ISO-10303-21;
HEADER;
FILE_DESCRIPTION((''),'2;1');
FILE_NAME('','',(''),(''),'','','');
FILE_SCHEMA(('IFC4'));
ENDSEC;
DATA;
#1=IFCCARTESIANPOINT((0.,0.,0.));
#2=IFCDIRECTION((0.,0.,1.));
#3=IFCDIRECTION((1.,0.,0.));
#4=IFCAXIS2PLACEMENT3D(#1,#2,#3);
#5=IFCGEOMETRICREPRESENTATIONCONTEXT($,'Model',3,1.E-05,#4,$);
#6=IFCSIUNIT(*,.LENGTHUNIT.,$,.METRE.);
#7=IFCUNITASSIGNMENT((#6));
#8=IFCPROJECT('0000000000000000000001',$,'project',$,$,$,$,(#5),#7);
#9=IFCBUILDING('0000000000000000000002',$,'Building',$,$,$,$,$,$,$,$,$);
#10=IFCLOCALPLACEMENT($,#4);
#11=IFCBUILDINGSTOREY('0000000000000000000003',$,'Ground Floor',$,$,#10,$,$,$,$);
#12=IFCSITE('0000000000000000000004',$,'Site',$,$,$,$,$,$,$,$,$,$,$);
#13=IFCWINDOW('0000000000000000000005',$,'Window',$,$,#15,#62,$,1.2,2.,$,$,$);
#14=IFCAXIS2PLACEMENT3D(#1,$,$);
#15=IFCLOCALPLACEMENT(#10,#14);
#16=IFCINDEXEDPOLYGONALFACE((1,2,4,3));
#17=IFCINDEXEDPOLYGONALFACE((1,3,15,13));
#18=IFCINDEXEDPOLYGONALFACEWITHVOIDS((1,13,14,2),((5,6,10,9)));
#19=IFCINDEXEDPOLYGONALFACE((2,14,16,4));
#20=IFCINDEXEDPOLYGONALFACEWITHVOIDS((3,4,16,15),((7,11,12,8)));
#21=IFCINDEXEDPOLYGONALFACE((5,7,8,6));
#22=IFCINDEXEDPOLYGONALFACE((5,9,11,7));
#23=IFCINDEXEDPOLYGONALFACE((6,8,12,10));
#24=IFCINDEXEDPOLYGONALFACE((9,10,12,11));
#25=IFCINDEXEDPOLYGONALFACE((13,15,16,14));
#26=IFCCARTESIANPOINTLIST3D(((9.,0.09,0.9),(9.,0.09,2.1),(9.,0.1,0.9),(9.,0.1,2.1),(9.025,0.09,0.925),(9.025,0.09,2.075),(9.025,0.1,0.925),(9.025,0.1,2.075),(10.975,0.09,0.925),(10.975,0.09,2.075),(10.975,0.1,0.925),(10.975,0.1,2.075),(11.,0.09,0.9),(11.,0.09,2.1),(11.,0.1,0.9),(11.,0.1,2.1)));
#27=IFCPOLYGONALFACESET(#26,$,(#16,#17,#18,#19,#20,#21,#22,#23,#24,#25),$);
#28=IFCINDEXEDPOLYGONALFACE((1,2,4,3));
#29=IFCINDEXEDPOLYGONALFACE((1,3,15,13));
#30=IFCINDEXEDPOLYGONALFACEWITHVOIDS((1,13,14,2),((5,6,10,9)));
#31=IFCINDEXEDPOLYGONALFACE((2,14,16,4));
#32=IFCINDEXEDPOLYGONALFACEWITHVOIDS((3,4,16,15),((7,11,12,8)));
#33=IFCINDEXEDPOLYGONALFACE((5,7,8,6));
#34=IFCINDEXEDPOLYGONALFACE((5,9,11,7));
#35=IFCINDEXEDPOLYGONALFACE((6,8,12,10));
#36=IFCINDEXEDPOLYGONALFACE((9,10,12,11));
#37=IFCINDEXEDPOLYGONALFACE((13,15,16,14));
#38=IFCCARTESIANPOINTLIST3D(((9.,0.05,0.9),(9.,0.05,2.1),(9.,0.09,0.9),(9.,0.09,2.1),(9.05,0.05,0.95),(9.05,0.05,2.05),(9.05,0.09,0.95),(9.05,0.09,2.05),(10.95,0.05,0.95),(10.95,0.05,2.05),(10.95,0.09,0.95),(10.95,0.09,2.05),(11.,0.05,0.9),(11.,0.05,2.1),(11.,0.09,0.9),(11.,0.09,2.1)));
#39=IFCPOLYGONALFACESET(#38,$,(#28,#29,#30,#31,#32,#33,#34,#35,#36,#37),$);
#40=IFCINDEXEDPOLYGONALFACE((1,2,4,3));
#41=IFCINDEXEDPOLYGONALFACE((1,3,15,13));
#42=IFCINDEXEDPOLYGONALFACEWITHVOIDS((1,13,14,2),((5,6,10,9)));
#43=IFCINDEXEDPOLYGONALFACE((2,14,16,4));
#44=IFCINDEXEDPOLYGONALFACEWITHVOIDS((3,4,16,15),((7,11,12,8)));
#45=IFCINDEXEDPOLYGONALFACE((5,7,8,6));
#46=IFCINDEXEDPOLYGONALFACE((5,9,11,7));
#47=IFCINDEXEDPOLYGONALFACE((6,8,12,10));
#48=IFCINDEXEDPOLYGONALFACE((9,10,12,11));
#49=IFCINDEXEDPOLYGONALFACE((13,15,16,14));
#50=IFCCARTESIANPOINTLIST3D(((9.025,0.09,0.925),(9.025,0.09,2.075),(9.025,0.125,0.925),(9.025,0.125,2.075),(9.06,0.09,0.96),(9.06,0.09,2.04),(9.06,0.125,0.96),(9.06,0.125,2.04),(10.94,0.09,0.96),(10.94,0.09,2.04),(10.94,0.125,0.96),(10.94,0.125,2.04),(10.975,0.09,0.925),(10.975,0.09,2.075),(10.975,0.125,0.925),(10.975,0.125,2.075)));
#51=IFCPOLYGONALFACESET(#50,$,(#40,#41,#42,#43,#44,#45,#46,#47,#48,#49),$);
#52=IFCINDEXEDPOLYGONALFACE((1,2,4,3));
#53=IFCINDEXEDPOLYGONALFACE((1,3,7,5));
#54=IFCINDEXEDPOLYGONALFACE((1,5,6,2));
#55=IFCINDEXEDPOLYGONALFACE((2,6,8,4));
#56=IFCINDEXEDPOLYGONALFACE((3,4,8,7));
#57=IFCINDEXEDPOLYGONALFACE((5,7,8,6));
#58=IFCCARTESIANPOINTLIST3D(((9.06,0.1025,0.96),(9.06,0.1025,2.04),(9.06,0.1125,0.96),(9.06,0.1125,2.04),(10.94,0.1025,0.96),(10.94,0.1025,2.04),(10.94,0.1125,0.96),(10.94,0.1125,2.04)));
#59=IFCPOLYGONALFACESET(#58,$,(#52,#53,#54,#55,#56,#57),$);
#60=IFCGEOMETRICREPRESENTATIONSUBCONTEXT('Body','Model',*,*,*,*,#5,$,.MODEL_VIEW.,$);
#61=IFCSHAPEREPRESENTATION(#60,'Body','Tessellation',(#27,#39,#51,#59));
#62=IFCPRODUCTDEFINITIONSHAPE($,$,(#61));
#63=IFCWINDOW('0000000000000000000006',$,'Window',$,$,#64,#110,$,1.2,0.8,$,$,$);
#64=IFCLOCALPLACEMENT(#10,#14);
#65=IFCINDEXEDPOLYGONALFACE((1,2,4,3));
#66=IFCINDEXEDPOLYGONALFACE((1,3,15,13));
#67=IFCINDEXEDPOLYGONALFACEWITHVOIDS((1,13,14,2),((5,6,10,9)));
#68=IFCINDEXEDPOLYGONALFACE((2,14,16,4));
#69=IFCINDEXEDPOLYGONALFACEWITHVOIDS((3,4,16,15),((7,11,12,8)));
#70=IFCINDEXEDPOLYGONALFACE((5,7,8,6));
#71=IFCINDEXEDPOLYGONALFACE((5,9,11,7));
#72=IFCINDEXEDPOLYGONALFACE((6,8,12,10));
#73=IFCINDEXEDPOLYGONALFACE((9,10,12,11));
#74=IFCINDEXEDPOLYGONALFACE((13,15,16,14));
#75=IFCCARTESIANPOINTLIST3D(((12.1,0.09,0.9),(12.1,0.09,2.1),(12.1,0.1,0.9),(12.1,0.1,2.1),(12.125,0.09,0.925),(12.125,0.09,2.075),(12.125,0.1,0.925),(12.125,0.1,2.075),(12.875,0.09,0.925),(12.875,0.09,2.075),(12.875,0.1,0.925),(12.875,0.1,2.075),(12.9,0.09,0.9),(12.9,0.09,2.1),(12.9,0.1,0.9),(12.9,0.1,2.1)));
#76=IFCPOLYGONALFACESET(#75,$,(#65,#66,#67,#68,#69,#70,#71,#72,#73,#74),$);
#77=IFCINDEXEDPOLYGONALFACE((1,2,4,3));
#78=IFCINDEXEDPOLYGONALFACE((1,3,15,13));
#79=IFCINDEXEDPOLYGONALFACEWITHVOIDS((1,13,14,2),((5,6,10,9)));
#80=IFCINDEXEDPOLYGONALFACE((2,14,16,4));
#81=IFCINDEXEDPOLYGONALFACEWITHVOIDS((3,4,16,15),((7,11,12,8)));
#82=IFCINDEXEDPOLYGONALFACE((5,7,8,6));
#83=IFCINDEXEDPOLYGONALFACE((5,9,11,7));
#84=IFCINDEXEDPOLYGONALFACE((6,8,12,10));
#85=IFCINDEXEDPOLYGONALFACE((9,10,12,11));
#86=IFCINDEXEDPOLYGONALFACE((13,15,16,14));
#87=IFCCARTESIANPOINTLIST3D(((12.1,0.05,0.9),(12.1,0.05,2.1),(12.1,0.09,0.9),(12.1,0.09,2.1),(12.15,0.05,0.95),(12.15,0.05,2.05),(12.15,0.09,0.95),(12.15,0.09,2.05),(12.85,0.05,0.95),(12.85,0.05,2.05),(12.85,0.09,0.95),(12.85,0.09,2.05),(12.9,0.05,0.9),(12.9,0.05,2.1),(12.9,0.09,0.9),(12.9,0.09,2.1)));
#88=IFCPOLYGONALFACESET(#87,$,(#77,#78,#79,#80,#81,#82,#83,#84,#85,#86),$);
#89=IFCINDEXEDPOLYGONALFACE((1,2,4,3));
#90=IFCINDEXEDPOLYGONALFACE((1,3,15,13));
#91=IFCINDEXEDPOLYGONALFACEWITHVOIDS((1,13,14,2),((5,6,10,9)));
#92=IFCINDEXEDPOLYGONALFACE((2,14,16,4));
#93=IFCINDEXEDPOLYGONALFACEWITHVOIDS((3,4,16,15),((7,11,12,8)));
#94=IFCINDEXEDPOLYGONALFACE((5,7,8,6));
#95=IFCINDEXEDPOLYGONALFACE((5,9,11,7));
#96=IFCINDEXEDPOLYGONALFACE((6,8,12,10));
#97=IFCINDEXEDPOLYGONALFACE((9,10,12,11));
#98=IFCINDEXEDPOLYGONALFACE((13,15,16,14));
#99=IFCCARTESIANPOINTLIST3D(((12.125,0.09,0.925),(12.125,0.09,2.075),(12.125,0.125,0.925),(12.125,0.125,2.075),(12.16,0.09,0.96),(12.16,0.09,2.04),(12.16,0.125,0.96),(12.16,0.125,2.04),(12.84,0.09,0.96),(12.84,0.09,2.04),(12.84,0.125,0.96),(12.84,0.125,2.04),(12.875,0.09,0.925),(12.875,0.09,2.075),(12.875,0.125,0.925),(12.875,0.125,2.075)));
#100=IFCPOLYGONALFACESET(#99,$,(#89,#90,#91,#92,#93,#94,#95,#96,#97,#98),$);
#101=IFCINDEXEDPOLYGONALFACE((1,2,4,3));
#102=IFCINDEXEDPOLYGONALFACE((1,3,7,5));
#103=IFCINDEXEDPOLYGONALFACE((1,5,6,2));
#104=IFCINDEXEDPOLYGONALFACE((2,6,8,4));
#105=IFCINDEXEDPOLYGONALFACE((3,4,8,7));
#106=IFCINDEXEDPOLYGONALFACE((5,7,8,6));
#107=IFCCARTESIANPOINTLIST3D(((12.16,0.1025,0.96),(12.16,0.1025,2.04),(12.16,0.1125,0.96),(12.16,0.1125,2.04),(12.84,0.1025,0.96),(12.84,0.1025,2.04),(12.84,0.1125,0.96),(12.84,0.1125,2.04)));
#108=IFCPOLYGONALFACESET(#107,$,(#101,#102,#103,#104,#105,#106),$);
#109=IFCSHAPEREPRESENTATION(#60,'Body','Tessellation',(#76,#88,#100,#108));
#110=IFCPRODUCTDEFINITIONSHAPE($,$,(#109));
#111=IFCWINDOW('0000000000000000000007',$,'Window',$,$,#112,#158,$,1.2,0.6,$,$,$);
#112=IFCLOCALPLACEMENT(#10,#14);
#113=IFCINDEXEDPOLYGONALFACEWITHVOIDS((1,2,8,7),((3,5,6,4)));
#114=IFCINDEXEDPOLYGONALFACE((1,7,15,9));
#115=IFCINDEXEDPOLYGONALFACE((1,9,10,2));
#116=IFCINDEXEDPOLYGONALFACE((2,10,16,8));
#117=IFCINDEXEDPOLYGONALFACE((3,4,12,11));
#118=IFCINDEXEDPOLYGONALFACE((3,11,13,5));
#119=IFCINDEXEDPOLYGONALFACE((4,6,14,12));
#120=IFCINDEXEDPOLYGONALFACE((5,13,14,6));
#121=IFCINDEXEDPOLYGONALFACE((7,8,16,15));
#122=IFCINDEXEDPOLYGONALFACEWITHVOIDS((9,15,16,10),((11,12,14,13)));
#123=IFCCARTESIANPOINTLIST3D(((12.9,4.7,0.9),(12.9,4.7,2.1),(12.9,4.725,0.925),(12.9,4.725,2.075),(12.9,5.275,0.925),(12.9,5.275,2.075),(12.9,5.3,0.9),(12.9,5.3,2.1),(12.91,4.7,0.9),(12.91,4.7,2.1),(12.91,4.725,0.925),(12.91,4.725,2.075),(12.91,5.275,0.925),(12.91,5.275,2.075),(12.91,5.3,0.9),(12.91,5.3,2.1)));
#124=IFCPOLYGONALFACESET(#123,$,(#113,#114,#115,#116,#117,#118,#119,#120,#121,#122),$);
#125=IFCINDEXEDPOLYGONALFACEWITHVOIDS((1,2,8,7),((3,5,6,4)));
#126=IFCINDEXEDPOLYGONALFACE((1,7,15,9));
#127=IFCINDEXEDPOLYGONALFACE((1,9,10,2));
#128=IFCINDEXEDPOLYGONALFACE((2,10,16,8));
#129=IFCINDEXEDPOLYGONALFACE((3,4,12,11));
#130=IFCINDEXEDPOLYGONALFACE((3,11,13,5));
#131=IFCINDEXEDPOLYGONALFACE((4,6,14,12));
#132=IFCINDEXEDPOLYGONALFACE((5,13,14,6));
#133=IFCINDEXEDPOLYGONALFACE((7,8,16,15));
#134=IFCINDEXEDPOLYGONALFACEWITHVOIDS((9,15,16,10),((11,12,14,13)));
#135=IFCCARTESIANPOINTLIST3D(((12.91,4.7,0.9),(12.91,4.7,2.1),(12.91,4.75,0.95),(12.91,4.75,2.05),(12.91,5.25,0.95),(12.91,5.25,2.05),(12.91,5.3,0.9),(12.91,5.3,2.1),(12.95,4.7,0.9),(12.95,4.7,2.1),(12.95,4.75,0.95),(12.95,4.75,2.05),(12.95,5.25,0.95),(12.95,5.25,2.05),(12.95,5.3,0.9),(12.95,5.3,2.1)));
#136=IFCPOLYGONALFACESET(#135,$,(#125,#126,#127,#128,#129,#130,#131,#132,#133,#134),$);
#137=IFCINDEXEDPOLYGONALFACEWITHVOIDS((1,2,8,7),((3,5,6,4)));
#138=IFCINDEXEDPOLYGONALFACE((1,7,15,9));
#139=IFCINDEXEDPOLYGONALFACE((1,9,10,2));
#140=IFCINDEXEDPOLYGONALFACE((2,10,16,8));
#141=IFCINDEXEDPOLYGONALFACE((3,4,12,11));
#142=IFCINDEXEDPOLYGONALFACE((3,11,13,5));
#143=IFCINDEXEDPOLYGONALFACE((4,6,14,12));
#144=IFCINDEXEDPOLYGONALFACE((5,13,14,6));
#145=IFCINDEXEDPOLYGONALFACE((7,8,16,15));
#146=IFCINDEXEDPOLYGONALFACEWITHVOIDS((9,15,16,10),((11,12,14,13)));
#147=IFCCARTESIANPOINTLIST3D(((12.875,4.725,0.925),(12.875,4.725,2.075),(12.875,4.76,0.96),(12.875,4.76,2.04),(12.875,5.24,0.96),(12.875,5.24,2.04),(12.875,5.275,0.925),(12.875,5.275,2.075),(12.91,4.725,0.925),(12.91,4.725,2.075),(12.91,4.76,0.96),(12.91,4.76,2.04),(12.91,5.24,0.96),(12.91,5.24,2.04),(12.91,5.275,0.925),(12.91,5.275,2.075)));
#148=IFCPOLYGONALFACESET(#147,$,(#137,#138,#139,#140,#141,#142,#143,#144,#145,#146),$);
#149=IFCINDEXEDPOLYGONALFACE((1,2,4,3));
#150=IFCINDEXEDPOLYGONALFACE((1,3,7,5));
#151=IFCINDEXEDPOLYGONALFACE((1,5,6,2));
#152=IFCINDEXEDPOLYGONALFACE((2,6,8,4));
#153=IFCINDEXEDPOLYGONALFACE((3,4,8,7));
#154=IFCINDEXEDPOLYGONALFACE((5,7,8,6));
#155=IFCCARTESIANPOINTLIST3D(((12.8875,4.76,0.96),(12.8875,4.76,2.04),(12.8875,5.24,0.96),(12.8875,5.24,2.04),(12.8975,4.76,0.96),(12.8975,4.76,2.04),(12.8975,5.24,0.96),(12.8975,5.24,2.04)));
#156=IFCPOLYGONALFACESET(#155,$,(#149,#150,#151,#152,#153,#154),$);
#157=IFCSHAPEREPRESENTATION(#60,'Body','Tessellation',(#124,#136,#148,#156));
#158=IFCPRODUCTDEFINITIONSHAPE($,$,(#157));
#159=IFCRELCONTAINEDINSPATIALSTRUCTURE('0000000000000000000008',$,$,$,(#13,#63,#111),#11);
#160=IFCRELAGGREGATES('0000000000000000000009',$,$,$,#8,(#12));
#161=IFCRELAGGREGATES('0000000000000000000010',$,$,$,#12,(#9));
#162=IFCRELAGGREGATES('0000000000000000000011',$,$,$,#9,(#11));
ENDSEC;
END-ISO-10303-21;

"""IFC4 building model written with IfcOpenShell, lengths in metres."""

from ifc_helpers import new_model, si_unit, frame, origin_with_axes, place, context, subcontext, project, spatial, line, indexed_curve, outline, extrude, element, save


model = new_model("IFC4")

# Units and contexts
model_context = context("Model", 3, precision=1e-05, world=origin_with_axes())
body_context = subcontext(model_context, "Body", "Model", "MODEL_VIEW")
ifc_project = project(units=[si_unit("LENGTHUNIT", "METRE")], contexts=[model_context])

# Site, building, storey
site = spatial("IfcSite", under=ifc_project, Name="Site")
building = spatial("IfcBuilding", under=site, Name="Building")
storey_placement = place(None, origin_with_axes())
storey = spatial("IfcBuildingStorey", under=building, at=storey_placement, Name="Ground Floor")

# Windows
window_1_placement = place(storey_placement, frame((9.0, 0.0, 0.9), z_axis=(0.0, 0.0, 1.0), x_axis=(1.0, 0.0, 0.0)))
element("IfcWindow", 1, at=window_1_placement, inside=storey, Name="Window", OverallHeight=1.2, OverallWidth=2.0, context=body_context, shape_type="SweptSolid", body=[
    extrude(outline(indexed_curve([(0.0, 0.0), (2.0, 0.0), (2.0, 1.2), (0.0, 1.2)], segments=[line(1, 2, 3, 4, 1)]), holes=[indexed_curve([(0.025, 0.025), (1.975, 0.025), (1.975, 1.175), (0.025, 1.175)], segments=[line(1, 2, 3, 4, 1)])]), frame((0.0, 0.09, 0.0), z_axis=(0.0, -1.0, 0.0), x_axis=(1.0, 0.0, 0.0)), (0.0, 0.0, -1.0), 0.01),
    extrude(outline(indexed_curve([(0.0, 0.0), (2.0, 0.0), (2.0, 1.2), (0.0, 1.2)], segments=[line(1, 2, 3, 4, 1)]), holes=[indexed_curve([(0.05, 0.05), (1.95, 0.05), (1.95, 1.15), (0.05, 1.15)], segments=[line(1, 2, 3, 4, 1)])]), frame((0.0, 0.05, 0.0), z_axis=(0.0, -1.0, 0.0), x_axis=(1.0, 0.0, 0.0)), (0.0, 0.0, -1.0), 0.04),
    extrude(outline(indexed_curve([(0.0, 0.0), (1.95, 0.0), (1.95, 1.15), (0.0, 1.15)], segments=[line(1, 2, 3, 4, 1)]), holes=[indexed_curve([(0.035, 0.035), (1.915, 0.035), (1.915, 1.115), (0.035, 1.115)], segments=[line(1, 2, 3, 4, 1)])]), frame((0.025, 0.09, 0.025), z_axis=(0.0, -1.0, 0.0), x_axis=(1.0, 0.0, 0.0)), (0.0, 0.0, -1.0), 0.035),
    extrude(outline(indexed_curve([(0.035, 0.035), (1.915, 0.035), (1.915, 1.115), (0.035, 1.115)], segments=[line(1, 2, 3, 4, 1)])), frame((0.025, 0.1025, 0.025), z_axis=(0.0, -1.0, 0.0), x_axis=(1.0, 0.0, 0.0)), (0.0, 0.0, -1.0), 0.01),
])
window_2_placement = place(storey_placement, frame((12.1, 0.0, 0.9), z_axis=(0.0, 0.0, 1.0), x_axis=(1.0, 0.0, 0.0)))
element("IfcWindow", 2, at=window_2_placement, inside=storey, Name="Window", OverallHeight=1.2, OverallWidth=0.8, context=body_context, shape_type="SweptSolid", body=[
    extrude(outline(indexed_curve([(0.0, 0.0), (0.8, 0.0), (0.8, 1.2), (0.0, 1.2)], segments=[line(1, 2, 3, 4, 1)]), holes=[indexed_curve([(0.025, 0.025), (0.775, 0.025), (0.775, 1.175), (0.025, 1.175)], segments=[line(1, 2, 3, 4, 1)])]), frame((0.0, 0.09, 0.0), z_axis=(0.0, -1.0, 0.0), x_axis=(1.0, 0.0, 0.0)), (0.0, 0.0, -1.0), 0.01),
    extrude(outline(indexed_curve([(0.0, 0.0), (0.8, 0.0), (0.8, 1.2), (0.0, 1.2)], segments=[line(1, 2, 3, 4, 1)]), holes=[indexed_curve([(0.05, 0.05), (0.75, 0.05), (0.75, 1.15), (0.05, 1.15)], segments=[line(1, 2, 3, 4, 1)])]), frame((0.0, 0.05, 0.0), z_axis=(0.0, -1.0, 0.0), x_axis=(1.0, 0.0, 0.0)), (0.0, 0.0, -1.0), 0.04),
    extrude(outline(indexed_curve([(0.0, 0.0), (0.75, 0.0), (0.75, 1.15), (0.0, 1.15)], segments=[line(1, 2, 3, 4, 1)]), holes=[indexed_curve([(0.035, 0.035), (0.715, 0.035), (0.715, 1.115), (0.035, 1.115)], segments=[line(1, 2, 3, 4, 1)])]), frame((0.025, 0.09, 0.025), z_axis=(0.0, -1.0, 0.0), x_axis=(1.0, 0.0, 0.0)), (0.0, 0.0, -1.0), 0.035),
    extrude(outline(indexed_curve([(0.035, 0.035), (0.715, 0.035), (0.715, 1.115), (0.035, 1.115)], segments=[line(1, 2, 3, 4, 1)])), frame((0.025, 0.1025, 0.025), z_axis=(0.0, -1.0, 0.0), x_axis=(1.0, 0.0, 0.0)), (0.0, 0.0, -1.0), 0.01),
])
window_3_placement = place(storey_placement, frame((13.0, 4.7, 0.9), z_axis=(0.0, 0.0, 1.0), x_axis=(0.0, 1.0, 0.0)))
element("IfcWindow", 3, at=window_3_placement, inside=storey, Name="Window", OverallHeight=1.2, OverallWidth=0.6, context=body_context, shape_type="SweptSolid", body=[
    extrude(outline(indexed_curve([(0.0, 0.0), (0.6, 0.0), (0.6, 1.2), (0.0, 1.2)], segments=[line(1, 2, 3, 4, 1)]), holes=[indexed_curve([(0.025, 0.025), (0.575, 0.025), (0.575, 1.175), (0.025, 1.175)], segments=[line(1, 2, 3, 4, 1)])]), frame((0.0, 0.09, 0.0), z_axis=(0.0, -1.0, 0.0), x_axis=(1.0, 0.0, 0.0)), (0.0, 0.0, -1.0), 0.01),
    extrude(outline(indexed_curve([(0.0, 0.0), (0.6, 0.0), (0.6, 1.2), (0.0, 1.2)], segments=[line(1, 2, 3, 4, 1)]), holes=[indexed_curve([(0.05, 0.05), (0.55, 0.05), (0.55, 1.15), (0.05, 1.15)], segments=[line(1, 2, 3, 4, 1)])]), frame((0.0, 0.05, 0.0), z_axis=(0.0, -1.0, 0.0), x_axis=(1.0, 0.0, 0.0)), (0.0, 0.0, -1.0), 0.04),
    extrude(outline(indexed_curve([(0.0, 0.0), (0.55, 0.0), (0.55, 1.15), (0.0, 1.15)], segments=[line(1, 2, 3, 4, 1)]), holes=[indexed_curve([(0.035, 0.035), (0.515, 0.035), (0.515, 1.115), (0.035, 1.115)], segments=[line(1, 2, 3, 4, 1)])]), frame((0.025, 0.09, 0.025), z_axis=(0.0, -1.0, 0.0), x_axis=(1.0, 0.0, 0.0)), (0.0, 0.0, -1.0), 0.035),
    extrude(outline(indexed_curve([(0.035, 0.035), (0.515, 0.035), (0.515, 1.115), (0.035, 1.115)], segments=[line(1, 2, 3, 4, 1)])), frame((0.025, 0.1025, 0.025), z_axis=(0.0, -1.0, 0.0), x_axis=(1.0, 0.0, 0.0)), (0.0, 0.0, -1.0), 0.01),
])

save(model, "model.ifc")
